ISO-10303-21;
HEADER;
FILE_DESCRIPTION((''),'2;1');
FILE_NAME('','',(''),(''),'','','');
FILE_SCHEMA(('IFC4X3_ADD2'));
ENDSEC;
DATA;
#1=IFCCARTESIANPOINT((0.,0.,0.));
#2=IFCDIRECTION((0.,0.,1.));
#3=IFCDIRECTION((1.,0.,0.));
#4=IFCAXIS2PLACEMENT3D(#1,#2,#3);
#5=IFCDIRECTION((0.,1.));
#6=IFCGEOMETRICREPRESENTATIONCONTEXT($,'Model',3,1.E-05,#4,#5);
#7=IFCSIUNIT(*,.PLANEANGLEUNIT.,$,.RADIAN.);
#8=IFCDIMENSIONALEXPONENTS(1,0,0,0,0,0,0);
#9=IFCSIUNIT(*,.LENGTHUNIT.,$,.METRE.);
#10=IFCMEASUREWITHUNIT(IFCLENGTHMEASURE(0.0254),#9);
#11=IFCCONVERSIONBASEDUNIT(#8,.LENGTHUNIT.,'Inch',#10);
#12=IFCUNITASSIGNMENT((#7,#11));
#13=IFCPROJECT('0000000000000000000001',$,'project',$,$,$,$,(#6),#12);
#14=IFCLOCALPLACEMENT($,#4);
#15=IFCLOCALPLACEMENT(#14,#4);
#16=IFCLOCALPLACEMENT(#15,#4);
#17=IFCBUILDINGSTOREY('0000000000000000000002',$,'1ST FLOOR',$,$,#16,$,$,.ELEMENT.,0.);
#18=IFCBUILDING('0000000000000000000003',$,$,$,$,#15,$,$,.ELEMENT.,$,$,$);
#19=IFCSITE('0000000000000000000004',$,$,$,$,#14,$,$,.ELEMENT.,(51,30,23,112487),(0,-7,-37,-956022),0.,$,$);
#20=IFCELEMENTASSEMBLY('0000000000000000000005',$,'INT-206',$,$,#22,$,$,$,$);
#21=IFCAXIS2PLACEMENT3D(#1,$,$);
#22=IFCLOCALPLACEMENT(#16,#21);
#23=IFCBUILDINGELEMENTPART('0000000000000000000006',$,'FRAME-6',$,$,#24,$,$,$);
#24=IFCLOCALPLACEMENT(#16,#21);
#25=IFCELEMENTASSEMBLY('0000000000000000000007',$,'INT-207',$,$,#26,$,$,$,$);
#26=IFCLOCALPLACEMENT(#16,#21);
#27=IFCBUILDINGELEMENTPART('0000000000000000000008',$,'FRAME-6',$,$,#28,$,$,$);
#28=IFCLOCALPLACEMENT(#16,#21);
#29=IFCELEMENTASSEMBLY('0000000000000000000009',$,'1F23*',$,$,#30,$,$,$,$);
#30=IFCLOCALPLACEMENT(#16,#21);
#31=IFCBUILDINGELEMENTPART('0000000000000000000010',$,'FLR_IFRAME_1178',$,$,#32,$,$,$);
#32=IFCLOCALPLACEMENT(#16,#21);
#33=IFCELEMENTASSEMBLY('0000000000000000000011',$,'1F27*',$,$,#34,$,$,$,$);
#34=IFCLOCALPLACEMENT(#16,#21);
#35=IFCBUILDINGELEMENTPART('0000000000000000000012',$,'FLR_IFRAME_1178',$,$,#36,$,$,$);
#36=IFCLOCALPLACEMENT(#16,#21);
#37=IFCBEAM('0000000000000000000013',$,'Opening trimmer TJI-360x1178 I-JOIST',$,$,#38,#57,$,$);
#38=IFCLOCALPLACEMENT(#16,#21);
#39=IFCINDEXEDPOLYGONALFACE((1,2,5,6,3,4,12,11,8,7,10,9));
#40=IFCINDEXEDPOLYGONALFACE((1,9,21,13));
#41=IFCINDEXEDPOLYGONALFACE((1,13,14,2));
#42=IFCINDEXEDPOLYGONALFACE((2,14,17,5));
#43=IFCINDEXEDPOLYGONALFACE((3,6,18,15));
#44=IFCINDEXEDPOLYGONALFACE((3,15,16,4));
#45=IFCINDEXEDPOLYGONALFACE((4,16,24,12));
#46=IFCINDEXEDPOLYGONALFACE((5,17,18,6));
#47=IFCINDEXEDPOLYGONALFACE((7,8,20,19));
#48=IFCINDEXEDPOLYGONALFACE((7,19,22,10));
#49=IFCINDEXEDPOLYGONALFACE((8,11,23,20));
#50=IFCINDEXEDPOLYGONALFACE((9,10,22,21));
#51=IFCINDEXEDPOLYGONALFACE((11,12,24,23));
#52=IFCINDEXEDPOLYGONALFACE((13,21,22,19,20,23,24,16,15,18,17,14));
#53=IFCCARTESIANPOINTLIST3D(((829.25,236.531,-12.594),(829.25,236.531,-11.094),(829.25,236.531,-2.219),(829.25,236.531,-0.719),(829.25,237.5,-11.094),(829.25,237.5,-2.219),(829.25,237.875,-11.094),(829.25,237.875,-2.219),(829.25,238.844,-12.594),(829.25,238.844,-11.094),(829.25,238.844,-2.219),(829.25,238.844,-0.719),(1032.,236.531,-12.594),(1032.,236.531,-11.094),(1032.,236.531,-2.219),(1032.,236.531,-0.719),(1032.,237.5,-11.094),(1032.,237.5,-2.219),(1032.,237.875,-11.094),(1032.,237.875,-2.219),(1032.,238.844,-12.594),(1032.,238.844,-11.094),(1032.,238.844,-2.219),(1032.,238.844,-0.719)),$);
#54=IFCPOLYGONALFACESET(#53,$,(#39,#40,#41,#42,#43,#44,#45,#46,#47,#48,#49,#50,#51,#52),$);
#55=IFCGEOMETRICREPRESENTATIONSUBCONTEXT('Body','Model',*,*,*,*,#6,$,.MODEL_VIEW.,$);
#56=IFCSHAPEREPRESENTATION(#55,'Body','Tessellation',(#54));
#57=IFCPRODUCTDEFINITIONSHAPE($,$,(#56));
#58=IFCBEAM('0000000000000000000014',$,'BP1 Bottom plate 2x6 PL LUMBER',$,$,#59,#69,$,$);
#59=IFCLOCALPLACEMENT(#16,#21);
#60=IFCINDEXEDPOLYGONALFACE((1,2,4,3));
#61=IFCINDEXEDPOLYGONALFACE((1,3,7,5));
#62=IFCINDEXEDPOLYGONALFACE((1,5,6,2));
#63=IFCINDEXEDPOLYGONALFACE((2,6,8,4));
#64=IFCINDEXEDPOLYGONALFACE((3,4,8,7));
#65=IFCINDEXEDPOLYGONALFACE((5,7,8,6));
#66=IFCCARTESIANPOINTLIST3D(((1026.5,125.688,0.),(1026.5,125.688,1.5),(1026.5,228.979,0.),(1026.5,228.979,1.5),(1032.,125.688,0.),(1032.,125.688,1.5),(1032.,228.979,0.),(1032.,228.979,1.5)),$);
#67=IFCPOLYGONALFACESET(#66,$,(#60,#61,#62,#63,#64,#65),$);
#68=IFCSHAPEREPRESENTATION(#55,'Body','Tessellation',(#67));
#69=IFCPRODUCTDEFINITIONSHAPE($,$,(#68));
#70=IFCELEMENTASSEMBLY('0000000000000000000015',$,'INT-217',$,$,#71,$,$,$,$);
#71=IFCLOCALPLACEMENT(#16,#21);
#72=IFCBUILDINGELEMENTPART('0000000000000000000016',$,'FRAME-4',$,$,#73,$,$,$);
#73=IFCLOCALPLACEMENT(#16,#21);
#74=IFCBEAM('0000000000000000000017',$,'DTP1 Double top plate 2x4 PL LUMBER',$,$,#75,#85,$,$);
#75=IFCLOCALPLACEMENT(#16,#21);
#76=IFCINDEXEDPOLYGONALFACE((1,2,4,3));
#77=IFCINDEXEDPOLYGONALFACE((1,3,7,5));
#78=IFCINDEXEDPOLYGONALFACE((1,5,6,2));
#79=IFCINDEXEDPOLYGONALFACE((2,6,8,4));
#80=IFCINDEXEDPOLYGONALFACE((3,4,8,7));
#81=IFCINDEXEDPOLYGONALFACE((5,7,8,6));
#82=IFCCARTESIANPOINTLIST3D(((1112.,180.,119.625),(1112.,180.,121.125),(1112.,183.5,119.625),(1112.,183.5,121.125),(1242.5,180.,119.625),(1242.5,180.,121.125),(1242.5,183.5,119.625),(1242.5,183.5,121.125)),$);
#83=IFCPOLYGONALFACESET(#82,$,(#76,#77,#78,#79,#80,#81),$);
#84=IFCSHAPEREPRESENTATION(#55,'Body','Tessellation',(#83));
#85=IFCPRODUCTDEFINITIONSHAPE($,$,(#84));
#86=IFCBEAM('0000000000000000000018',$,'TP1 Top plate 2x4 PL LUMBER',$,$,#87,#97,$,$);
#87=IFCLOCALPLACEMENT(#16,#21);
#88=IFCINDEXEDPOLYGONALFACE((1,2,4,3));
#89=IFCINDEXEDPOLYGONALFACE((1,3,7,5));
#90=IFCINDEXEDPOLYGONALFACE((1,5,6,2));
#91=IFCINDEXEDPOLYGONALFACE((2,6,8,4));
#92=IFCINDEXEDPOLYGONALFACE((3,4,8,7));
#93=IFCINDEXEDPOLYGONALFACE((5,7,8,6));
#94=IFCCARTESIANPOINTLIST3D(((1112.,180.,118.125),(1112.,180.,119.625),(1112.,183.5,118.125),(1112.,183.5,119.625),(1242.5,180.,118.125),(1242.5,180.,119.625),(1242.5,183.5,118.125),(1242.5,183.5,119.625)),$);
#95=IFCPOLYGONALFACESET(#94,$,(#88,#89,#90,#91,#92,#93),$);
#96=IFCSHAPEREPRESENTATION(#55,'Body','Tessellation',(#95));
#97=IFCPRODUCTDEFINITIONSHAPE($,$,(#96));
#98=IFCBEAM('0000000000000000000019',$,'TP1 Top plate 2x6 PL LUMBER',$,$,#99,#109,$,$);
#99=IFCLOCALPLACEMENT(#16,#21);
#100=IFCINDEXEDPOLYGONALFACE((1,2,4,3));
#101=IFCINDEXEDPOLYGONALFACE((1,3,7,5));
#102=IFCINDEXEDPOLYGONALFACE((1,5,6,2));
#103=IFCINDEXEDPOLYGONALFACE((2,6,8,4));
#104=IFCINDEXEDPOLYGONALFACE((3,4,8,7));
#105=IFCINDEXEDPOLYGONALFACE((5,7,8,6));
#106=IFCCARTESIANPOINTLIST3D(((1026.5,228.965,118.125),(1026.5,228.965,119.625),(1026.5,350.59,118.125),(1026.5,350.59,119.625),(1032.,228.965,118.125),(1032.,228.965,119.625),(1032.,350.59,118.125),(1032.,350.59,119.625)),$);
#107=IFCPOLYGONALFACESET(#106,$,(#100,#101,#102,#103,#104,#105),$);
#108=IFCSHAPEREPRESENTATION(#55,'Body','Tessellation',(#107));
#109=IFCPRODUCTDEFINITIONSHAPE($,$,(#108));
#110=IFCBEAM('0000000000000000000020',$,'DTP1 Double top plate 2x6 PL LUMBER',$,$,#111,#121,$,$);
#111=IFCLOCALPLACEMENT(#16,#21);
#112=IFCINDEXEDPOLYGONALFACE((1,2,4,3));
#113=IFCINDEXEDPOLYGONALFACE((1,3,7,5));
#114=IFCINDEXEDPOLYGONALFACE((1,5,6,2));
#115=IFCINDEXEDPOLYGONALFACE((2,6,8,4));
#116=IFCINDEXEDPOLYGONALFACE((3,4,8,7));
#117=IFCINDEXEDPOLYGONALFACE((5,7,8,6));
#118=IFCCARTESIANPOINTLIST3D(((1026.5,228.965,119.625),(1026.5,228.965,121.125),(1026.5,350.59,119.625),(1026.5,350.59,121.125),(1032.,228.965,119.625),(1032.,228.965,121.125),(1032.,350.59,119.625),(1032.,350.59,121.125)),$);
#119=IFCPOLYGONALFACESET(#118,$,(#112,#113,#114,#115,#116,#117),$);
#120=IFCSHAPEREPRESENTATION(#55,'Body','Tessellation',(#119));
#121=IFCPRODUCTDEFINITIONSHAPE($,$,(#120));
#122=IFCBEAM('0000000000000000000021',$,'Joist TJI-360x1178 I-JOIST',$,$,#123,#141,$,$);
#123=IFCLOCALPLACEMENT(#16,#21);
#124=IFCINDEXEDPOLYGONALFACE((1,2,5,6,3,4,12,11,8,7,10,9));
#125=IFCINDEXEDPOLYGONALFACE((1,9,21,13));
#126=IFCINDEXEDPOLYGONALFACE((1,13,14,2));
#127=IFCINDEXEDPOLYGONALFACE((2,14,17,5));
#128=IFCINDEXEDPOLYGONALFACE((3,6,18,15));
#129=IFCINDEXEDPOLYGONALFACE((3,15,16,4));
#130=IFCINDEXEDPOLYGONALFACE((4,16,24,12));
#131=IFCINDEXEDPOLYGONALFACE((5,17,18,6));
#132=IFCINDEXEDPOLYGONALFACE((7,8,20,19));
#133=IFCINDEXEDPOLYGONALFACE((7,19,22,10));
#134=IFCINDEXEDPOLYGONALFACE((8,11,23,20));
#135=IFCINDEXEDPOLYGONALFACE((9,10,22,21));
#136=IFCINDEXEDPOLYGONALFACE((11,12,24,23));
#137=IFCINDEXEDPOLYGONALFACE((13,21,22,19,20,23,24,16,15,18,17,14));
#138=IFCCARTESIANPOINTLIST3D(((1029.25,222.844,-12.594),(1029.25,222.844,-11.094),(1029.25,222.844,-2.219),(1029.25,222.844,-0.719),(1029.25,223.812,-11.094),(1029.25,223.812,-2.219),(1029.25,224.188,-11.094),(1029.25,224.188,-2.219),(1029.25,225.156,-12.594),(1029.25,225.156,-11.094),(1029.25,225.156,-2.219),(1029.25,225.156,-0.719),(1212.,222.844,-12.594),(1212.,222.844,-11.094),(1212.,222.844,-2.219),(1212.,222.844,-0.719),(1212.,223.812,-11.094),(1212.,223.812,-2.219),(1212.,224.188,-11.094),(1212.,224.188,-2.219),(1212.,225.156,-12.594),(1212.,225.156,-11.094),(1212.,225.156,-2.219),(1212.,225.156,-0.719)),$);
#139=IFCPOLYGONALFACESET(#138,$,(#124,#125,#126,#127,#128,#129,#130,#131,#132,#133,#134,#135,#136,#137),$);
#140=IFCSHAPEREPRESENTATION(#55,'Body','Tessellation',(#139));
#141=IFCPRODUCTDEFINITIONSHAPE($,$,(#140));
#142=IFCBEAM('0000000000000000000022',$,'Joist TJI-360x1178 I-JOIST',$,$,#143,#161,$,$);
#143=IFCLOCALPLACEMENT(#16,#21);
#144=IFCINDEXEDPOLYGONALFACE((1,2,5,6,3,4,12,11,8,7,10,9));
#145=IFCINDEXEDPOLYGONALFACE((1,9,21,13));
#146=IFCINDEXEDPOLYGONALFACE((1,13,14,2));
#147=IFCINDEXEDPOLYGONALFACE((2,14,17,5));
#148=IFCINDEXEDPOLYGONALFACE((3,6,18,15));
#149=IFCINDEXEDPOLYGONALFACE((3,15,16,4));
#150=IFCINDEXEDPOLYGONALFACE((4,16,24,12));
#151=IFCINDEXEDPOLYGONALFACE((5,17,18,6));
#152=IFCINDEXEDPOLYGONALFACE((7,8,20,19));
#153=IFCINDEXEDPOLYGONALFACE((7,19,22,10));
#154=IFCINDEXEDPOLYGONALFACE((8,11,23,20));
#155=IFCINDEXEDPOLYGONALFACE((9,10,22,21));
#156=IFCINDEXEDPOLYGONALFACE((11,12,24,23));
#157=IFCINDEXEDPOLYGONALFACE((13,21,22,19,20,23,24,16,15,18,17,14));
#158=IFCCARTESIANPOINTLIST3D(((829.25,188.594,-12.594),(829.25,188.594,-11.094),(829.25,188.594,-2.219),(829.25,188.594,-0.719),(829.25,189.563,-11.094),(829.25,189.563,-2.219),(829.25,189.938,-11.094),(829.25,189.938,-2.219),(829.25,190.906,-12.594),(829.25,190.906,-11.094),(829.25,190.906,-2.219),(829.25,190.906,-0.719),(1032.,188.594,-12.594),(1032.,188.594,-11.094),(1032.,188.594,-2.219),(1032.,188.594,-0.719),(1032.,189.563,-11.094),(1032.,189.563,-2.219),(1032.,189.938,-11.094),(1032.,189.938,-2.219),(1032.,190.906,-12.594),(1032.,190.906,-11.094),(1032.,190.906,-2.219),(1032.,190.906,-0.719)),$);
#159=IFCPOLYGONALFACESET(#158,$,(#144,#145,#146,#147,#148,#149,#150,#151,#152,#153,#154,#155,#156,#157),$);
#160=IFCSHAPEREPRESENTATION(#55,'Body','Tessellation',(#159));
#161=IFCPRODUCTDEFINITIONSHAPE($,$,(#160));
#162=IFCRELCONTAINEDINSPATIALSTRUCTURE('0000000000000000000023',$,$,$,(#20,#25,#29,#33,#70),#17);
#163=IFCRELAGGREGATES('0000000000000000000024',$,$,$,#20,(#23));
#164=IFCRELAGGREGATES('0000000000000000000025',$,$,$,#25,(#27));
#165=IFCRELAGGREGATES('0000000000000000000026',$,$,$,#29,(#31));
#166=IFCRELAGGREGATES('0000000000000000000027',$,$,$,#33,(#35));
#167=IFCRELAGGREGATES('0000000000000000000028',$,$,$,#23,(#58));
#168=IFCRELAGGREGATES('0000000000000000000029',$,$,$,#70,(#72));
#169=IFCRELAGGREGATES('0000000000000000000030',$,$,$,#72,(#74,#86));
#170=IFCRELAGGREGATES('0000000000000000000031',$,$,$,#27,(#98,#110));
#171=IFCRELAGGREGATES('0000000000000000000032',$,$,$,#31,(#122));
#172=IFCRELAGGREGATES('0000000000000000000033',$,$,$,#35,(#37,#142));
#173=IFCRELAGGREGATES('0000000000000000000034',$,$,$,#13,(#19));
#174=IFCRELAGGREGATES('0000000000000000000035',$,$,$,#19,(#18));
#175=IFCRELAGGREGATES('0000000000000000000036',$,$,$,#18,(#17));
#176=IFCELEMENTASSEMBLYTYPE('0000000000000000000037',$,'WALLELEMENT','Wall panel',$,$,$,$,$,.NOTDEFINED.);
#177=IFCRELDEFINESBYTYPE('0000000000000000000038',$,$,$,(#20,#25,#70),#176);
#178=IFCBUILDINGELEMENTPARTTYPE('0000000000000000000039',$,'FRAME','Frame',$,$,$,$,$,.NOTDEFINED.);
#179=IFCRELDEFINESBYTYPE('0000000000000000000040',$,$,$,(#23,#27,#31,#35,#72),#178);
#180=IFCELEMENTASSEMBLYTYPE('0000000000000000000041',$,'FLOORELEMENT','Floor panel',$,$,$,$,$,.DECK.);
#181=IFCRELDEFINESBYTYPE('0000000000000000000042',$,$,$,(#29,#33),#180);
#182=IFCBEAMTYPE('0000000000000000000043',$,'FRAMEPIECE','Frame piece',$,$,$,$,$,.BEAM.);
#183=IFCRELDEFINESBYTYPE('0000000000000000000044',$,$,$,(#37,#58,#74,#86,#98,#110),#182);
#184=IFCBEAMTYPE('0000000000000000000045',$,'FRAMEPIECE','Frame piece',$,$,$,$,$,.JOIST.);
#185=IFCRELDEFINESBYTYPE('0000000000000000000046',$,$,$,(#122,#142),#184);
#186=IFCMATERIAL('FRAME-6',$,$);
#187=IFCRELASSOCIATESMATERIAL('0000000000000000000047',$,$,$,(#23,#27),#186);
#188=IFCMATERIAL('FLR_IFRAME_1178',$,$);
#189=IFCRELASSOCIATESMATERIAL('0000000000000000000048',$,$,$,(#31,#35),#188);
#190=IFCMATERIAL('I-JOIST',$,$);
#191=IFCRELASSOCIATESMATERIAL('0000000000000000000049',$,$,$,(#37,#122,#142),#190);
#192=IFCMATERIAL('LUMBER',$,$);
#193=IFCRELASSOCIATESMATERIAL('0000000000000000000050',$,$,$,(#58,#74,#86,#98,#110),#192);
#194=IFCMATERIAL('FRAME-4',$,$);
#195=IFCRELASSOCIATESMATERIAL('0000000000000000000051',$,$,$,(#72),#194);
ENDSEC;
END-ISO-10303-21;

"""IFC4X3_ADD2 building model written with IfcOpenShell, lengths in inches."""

from ifc_helpers import new_model, entity, si_unit, converted_unit, direction, frame, origin_with_axes, origin_2d_with_axis, place, context, subcontext, project, spatial, rectangle, i_section, extrude, material, type_object, element, aggregate, save


model = new_model("IFC4X3_ADD2")

# Units and contexts
model_context = context("Model", 3, precision=1e-05, world=origin_with_axes(), true_north=direction((0.0, 1.0)))
body_context = subcontext(model_context, "Body", "Model", "MODEL_VIEW")
ifc_project = project(units=[si_unit("PLANEANGLEUNIT", "RADIAN"), converted_unit("LENGTHUNIT", "Inch", entity("IfcLengthMeasure", 0.0254), si_unit("LENGTHUNIT", "METRE"), dimensions=[1, 0, 0, 0, 0, 0, 0])], contexts=[model_context])

# Site, building, storey
site_placement = place(None, origin_with_axes())
site = spatial("IfcSite", under=ifc_project, at=site_placement, CompositionType="ELEMENT", RefLatitude=(51, 30, 23, 112487), RefLongitude=(0, -7, -37, -956022), RefElevation=0.0)
building_placement = place(site_placement, origin_with_axes())
building = spatial("IfcBuilding", under=site, at=building_placement, CompositionType="ELEMENT")
storey_placement = place(building_placement, origin_with_axes())
storey = spatial("IfcBuildingStorey", under=building, at=storey_placement, Name="1ST FLOOR", CompositionType="ELEMENT", Elevation=0.0)

# Element assemblies, building element parts
element_assembly_type_1 = type_object("IfcElementAssemblyType", Name="WALLELEMENT", Description="Wall panel", PredefinedType="NOTDEFINED")
assembly_1_placement = place(storey_placement, origin_with_axes())
assembly_1 = element("IfcElementAssembly", 1, at=assembly_1_placement, inside=storey, type_object=element_assembly_type_1, Name="INT-206")
ifc_material_1 = material(Name="FRAME-6")
building_element_part_type = type_object("IfcBuildingElementPartType", Name="FRAME", Description="Frame", PredefinedType="NOTDEFINED")
building_element_part_1_placement = place(storey_placement, origin_with_axes())
building_element_part_1 = element("IfcBuildingElementPart", 2, at=building_element_part_1_placement, type_object=building_element_part_type, material=ifc_material_1, Name="FRAME-6")
aggregate(assembly_1, [building_element_part_1])
ifc_material_2 = material(Name="LUMBER")
assembly_2_placement = place(storey_placement, origin_with_axes())
assembly_2 = element("IfcElementAssembly", 3, at=assembly_2_placement, inside=storey, type_object=element_assembly_type_1, Name="INT-207")
building_element_part_2_placement = place(storey_placement, origin_with_axes())
building_element_part_2 = element("IfcBuildingElementPart", 4, at=building_element_part_2_placement, type_object=building_element_part_type, material=ifc_material_1, Name="FRAME-6")
aggregate(assembly_2, [building_element_part_2])

# Element assembly, building element part
element_assembly_type_2 = type_object("IfcElementAssemblyType", Name="FLOORELEMENT", Description="Floor panel", PredefinedType="DECK")
ifc_material_3 = material(Name="FLR_IFRAME_1178")
beam_type_1 = type_object("IfcBeamType", Name="FRAMEPIECE", Description="Frame piece", PredefinedType="BEAM")
assembly_3_placement = place(storey_placement, origin_with_axes())
assembly_3 = element("IfcElementAssembly", 5, at=assembly_3_placement, inside=storey, type_object=element_assembly_type_2, Name="1F23*")
building_element_part_3_placement = place(storey_placement, origin_with_axes())
building_element_part_3 = element("IfcBuildingElementPart", 6, at=building_element_part_3_placement, type_object=building_element_part_type, material=ifc_material_3, Name="FLR_IFRAME_1178")
aggregate(assembly_3, [building_element_part_3])

# Element assembly, building element part, beam
assembly_4_placement = place(storey_placement, origin_with_axes())
assembly_4 = element("IfcElementAssembly", 7, at=assembly_4_placement, inside=storey, type_object=element_assembly_type_2, Name="1F27*")
building_element_part_4_placement = place(storey_placement, origin_with_axes())
building_element_part_4 = element("IfcBuildingElementPart", 8, at=building_element_part_4_placement, type_object=building_element_part_type, material=ifc_material_3, Name="FLR_IFRAME_1178")
aggregate(assembly_4, [building_element_part_4])
ifc_material_4 = material(Name="I-JOIST")
beam_1_placement = place(storey_placement, frame((1032.0, 237.687, -6.656), z_axis=(-1.0, 0.0, 0.0), x_axis=(0.0, -1.0, 0.0)))
beam_1 = element("IfcBeam", 9, at=beam_1_placement, type_object=beam_type_1, material=ifc_material_4, Name="Opening trimmer TJI-360x1178 I-JOIST", context=body_context, shape_type="SweptSolid", body=[
    extrude(i_section(OverallWidth=2.313, OverallDepth=11.875, WebThickness=0.375, FlangeThickness=1.5, at=origin_2d_with_axis()), origin_with_axes(), (0.0, 0.0, 1.0), 202.75),
])

# Beam
beam_2_placement = place(storey_placement, frame((1029.25, 228.979, 0.75), z_axis=(0.0, -1.0, 0.0), x_axis=(0.0, 0.0, 1.0)))
beam_2 = element("IfcBeam", 10, at=beam_2_placement, type_object=beam_type_1, material=ifc_material_2, Name="BP1 Bottom plate 2x6 PL LUMBER", context=body_context, shape_type="SweptSolid", body=[
    extrude(rectangle(XDim=1.5, YDim=5.5, at=origin_2d_with_axis()), origin_with_axes(), (0.0, 0.0, 1.0), 103.292),
])
aggregate(building_element_part_1, [beam_2])

# Element assembly, building element part, beams
assembly_5_placement = place(storey_placement, origin_with_axes())
assembly_5 = element("IfcElementAssembly", 11, at=assembly_5_placement, inside=storey, type_object=element_assembly_type_1, Name="INT-217")
ifc_material_5 = material(Name="FRAME-4")
building_element_part_5_placement = place(storey_placement, origin_with_axes())
building_element_part_5 = element("IfcBuildingElementPart", 12, at=building_element_part_5_placement, type_object=building_element_part_type, material=ifc_material_5, Name="FRAME-4")
aggregate(assembly_5, [building_element_part_5])
beam_3_placement = place(storey_placement, frame((1112.0, 181.75, 120.375), z_axis=(1.0, 0.0, 0.0), x_axis=(0.0, 0.0, -1.0)))
beam_3 = element("IfcBeam", 13, at=beam_3_placement, type_object=beam_type_1, material=ifc_material_2, Name="DTP1 Double top plate 2x4 PL LUMBER", context=body_context, shape_type="SweptSolid", body=[
    extrude(rectangle(XDim=1.5, YDim=3.5, at=origin_2d_with_axis()), origin_with_axes(), (0.0, 0.0, 1.0), 130.5),
])
beam_4_placement = place(storey_placement, frame((1112.0, 181.75, 118.875), z_axis=(1.0, 0.0, 0.0), x_axis=(0.0, 0.0, -1.0)))
beam_4 = element("IfcBeam", 14, at=beam_4_placement, type_object=beam_type_1, material=ifc_material_2, Name="TP1 Top plate 2x4 PL LUMBER", context=body_context, shape_type="SweptSolid", body=[
    extrude(rectangle(XDim=1.5, YDim=3.5, at=origin_2d_with_axis()), origin_with_axes(), (0.0, 0.0, 1.0), 130.5),
])
aggregate(building_element_part_5, [beam_3, beam_4])

# Beams
beam_5_placement = place(storey_placement, frame((1029.25, 228.965, 118.875), z_axis=(0.0, 1.0, 0.0), x_axis=(0.0, 0.0, -1.0)))
beam_5 = element("IfcBeam", 15, at=beam_5_placement, type_object=beam_type_1, material=ifc_material_2, Name="TP1 Top plate 2x6 PL LUMBER", context=body_context, shape_type="SweptSolid", body=[
    extrude(rectangle(XDim=1.5, YDim=5.5, at=origin_2d_with_axis()), origin_with_axes(), (0.0, 0.0, 1.0), 121.625),
])
beam_6_placement = place(storey_placement, frame((1029.25, 228.965, 120.375), z_axis=(0.0, 1.0, 0.0), x_axis=(0.0, 0.0, -1.0)))
beam_6 = element("IfcBeam", 16, at=beam_6_placement, type_object=beam_type_1, material=ifc_material_2, Name="DTP1 Double top plate 2x6 PL LUMBER", context=body_context, shape_type="SweptSolid", body=[
    extrude(rectangle(XDim=1.5, YDim=5.5, at=origin_2d_with_axis()), origin_with_axes(), (0.0, 0.0, 1.0), 121.625),
])
aggregate(building_element_part_2, [beam_5, beam_6])
beam_type_2 = type_object("IfcBeamType", Name="FRAMEPIECE", Description="Frame piece", PredefinedType="JOIST")
beam_7_placement = place(storey_placement, frame((1029.25, 224.0, -6.656), z_axis=(1.0, 0.0, 0.0), x_axis=(0.0, 1.0, 0.0)))
beam_7 = element("IfcBeam", 17, at=beam_7_placement, type_object=beam_type_2, material=ifc_material_4, Name="Joist TJI-360x1178 I-JOIST", context=body_context, shape_type="SweptSolid", body=[
    extrude(i_section(OverallWidth=2.313, OverallDepth=11.875, WebThickness=0.375, FlangeThickness=1.5, at=origin_2d_with_axis()), origin_with_axes(), (0.0, 0.0, 1.0), 182.75),
])
aggregate(building_element_part_3, [beam_7])
beam_8_placement = place(storey_placement, frame((1032.0, 189.75, -6.656), z_axis=(-1.0, 0.0, 0.0), x_axis=(0.0, -1.0, 0.0)))
beam_8 = element("IfcBeam", 18, at=beam_8_placement, type_object=beam_type_2, material=ifc_material_4, Name="Joist TJI-360x1178 I-JOIST", context=body_context, shape_type="SweptSolid", body=[
    extrude(i_section(OverallWidth=2.313, OverallDepth=11.875, WebThickness=0.375, FlangeThickness=1.5, at=origin_2d_with_axis()), origin_with_axes(), (0.0, 0.0, 1.0), 202.75),
])
aggregate(building_element_part_4, [beam_1, beam_8])

save(model, "model.ifc")
